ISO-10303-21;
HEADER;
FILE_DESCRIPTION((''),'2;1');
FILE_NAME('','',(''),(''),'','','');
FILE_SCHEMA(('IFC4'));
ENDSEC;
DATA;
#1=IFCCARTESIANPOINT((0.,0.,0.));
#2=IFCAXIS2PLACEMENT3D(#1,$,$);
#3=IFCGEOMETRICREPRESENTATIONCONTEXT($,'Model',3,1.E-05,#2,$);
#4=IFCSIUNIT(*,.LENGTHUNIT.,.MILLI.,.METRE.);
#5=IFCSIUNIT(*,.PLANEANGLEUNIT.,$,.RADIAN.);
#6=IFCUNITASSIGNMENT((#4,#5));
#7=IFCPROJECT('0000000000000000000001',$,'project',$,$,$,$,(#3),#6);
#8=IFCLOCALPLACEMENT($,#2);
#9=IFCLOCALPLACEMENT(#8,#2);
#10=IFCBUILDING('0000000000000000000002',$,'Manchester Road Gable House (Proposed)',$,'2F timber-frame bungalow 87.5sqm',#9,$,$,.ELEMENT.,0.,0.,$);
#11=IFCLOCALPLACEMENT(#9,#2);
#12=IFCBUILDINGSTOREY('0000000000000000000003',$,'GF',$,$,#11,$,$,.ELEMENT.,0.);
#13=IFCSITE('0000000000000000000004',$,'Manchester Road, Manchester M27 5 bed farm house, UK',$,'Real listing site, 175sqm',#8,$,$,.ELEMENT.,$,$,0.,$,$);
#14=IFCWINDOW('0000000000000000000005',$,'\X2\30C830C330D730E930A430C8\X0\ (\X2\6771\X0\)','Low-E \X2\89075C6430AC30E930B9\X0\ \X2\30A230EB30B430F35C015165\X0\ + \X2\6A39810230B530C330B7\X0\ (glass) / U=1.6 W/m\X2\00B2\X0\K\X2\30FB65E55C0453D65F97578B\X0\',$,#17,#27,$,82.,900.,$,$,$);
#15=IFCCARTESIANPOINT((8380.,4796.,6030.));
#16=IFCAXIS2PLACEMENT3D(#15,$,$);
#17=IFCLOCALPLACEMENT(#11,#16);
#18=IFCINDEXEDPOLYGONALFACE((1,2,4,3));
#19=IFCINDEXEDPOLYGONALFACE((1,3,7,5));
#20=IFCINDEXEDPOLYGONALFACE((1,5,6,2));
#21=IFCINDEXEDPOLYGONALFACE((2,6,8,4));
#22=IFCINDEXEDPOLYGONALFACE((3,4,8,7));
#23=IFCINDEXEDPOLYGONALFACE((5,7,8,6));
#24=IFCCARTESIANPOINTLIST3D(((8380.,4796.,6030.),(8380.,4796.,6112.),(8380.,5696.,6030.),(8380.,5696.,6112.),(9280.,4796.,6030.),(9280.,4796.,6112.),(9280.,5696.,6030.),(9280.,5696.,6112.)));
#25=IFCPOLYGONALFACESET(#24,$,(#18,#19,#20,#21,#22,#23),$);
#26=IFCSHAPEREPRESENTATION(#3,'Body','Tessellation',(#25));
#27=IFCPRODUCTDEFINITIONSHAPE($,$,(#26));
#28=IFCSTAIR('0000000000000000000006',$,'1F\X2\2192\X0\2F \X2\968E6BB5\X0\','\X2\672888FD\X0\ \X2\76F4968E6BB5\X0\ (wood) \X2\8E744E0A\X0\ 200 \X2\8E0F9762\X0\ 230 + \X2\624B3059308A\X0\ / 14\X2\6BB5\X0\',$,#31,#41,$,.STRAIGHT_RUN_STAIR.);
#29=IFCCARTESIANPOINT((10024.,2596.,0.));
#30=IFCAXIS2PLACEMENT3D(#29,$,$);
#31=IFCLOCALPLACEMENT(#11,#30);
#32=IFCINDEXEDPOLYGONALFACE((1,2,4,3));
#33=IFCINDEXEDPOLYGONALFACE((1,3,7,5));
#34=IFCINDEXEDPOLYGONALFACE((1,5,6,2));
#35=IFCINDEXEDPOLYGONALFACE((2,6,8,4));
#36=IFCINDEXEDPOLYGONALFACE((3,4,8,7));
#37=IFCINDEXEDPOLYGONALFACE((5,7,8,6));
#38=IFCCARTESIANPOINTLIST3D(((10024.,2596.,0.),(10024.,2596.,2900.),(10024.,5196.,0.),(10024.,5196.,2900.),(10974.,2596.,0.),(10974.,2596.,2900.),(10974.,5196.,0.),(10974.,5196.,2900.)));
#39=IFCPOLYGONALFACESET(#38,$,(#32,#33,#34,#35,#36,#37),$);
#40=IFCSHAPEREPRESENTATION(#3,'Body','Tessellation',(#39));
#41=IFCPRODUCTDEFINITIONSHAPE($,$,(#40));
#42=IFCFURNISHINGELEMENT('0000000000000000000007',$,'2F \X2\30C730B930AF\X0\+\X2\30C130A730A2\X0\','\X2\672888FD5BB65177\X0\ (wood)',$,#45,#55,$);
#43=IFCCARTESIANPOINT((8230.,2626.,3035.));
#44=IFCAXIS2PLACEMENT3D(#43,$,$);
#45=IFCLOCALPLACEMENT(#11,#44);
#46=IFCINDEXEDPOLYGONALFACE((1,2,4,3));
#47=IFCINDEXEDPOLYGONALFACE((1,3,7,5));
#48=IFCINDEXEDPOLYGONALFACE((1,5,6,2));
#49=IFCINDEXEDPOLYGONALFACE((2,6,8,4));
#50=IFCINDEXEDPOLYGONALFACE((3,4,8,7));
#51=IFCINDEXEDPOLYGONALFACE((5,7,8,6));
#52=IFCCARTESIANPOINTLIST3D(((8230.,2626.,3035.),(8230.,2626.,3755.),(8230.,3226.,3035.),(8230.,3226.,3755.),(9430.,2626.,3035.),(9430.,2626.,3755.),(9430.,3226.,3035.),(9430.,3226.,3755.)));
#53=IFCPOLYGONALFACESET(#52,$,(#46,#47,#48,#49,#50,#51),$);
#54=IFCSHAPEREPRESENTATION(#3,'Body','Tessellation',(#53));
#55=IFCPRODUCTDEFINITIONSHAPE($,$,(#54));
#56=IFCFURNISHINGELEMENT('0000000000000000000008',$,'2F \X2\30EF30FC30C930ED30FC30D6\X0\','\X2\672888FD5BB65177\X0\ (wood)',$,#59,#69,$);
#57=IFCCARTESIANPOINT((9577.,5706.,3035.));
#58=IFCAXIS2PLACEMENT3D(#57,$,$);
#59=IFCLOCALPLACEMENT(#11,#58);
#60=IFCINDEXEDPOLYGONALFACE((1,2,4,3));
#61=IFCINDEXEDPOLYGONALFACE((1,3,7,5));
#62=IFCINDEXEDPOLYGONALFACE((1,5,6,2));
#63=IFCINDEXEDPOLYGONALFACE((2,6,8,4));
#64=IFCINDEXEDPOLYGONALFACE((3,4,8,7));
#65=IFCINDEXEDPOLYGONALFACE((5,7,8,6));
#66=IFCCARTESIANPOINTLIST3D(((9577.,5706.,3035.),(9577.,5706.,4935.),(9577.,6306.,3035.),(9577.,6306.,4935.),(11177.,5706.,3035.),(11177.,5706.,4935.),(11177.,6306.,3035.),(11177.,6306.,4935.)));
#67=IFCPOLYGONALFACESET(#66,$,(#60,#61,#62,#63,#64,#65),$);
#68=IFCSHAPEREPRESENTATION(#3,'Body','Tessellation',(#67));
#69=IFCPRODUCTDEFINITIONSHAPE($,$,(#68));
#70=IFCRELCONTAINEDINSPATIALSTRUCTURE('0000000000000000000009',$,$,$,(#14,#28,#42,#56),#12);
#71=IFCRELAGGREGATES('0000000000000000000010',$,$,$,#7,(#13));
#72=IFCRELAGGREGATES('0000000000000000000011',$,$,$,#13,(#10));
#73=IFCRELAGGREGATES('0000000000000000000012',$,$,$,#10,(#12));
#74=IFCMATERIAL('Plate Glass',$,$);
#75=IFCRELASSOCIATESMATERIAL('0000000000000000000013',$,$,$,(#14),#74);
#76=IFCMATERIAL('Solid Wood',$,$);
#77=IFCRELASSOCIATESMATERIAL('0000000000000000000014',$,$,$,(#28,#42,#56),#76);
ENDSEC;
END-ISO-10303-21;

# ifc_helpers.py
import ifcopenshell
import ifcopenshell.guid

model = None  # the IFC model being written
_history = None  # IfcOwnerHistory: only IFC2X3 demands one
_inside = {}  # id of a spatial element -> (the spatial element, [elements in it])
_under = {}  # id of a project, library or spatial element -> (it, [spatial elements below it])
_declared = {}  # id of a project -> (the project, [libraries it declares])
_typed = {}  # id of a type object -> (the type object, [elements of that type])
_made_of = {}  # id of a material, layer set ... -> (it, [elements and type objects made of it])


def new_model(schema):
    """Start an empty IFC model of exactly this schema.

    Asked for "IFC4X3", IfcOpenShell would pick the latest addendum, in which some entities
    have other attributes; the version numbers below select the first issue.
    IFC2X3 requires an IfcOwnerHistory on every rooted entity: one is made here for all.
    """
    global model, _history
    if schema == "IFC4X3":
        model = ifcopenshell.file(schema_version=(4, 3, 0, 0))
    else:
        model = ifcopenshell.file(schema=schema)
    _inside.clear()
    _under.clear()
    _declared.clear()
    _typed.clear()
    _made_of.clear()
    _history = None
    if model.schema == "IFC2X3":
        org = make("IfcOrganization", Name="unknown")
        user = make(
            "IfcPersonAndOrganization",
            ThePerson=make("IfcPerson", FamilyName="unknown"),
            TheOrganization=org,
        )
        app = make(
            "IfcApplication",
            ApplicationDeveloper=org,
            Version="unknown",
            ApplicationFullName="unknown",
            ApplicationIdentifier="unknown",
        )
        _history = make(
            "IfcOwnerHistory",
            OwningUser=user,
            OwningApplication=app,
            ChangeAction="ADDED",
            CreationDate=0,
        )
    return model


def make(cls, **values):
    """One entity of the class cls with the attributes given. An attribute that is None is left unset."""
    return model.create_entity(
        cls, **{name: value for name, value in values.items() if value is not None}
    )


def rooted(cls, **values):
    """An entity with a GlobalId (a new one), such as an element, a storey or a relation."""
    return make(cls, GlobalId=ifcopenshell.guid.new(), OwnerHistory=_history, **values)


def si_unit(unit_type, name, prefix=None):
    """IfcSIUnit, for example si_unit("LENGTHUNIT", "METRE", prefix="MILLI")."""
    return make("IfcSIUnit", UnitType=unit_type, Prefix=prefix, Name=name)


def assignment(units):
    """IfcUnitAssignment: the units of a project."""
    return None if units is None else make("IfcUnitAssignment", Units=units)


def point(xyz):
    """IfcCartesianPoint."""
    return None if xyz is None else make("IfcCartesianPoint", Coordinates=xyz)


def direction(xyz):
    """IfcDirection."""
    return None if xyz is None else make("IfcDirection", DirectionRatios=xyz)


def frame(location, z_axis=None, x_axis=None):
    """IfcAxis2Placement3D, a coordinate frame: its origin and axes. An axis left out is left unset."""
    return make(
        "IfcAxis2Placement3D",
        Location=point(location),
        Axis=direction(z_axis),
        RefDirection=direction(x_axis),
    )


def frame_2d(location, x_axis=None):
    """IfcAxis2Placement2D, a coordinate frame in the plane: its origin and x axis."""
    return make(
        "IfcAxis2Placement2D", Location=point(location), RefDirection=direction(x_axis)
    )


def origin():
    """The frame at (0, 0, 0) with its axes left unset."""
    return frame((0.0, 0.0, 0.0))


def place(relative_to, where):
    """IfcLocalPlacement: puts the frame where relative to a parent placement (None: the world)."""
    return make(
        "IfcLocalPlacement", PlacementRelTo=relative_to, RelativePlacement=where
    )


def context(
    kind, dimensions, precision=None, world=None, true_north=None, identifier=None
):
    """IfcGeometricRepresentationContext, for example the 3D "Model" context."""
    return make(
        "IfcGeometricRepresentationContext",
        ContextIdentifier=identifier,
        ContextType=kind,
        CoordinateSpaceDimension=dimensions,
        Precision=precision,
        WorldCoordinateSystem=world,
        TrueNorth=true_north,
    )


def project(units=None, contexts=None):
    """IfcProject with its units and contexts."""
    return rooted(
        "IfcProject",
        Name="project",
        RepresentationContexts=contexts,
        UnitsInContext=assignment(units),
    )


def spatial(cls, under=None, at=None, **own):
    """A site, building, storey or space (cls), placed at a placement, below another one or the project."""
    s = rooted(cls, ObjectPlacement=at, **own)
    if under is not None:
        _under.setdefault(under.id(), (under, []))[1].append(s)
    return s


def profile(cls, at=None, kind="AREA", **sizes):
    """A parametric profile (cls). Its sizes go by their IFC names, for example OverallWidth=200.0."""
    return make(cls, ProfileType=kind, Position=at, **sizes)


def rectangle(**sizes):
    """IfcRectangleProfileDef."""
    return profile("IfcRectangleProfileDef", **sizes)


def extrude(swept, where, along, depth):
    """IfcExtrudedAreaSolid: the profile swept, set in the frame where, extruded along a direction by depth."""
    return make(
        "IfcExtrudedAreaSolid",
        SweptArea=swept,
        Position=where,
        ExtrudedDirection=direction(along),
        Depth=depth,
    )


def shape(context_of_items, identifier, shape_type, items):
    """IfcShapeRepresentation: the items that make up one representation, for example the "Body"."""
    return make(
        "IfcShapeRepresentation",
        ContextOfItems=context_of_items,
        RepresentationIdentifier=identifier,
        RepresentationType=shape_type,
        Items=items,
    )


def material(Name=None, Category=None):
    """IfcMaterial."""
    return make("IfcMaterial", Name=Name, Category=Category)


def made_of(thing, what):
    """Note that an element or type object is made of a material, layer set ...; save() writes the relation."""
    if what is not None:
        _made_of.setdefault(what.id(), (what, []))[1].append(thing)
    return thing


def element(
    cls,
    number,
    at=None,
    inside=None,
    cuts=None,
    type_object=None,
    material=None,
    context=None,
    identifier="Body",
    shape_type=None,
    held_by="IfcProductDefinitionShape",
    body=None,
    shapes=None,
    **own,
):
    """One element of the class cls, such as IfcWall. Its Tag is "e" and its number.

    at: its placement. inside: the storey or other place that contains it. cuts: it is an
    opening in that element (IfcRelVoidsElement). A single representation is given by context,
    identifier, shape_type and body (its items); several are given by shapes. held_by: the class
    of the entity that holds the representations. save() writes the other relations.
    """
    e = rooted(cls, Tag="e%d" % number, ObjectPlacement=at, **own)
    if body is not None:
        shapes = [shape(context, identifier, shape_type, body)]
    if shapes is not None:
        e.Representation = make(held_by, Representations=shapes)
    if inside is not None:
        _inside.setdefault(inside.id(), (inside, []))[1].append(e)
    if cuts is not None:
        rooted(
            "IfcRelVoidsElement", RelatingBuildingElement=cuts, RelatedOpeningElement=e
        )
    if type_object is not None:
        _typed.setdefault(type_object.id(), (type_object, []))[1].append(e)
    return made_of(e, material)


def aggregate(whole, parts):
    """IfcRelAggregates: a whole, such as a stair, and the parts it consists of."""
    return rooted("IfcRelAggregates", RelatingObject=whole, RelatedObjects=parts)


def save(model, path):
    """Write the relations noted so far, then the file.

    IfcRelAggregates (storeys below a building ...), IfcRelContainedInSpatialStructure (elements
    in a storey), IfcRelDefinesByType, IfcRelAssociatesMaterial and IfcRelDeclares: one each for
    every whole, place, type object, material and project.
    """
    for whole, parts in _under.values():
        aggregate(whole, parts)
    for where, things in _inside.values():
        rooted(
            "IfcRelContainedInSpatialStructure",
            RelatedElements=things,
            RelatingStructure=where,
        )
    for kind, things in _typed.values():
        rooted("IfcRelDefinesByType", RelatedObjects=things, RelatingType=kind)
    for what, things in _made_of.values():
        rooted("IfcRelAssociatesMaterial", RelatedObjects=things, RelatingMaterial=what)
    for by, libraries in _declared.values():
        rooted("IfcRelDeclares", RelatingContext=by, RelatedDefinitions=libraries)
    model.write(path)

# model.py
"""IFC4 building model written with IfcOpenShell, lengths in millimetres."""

from ifc_helpers import new_model, si_unit, frame, frame_2d, origin, place, context, project, spatial, rectangle, extrude, material, element, save


model = new_model("IFC4")

# Units and contexts
model_context = context("Model", 3, precision=1e-05, world=origin())
ifc_project = project(units=[si_unit("LENGTHUNIT", "METRE", prefix="MILLI"), si_unit("PLANEANGLEUNIT", "RADIAN")], contexts=[model_context])

# Site, building, storey
site_placement = place(None, origin())
site = spatial("IfcSite", under=ifc_project, at=site_placement, Name="Manchester Road, Manchester M27 5 bed farm house, UK", ObjectType="Real listing site, 175sqm", CompositionType="ELEMENT", RefElevation=0.0)
building_placement = place(site_placement, origin())
building = spatial("IfcBuilding", under=site, at=building_placement, Name="Manchester Road Gable House (Proposed)", ObjectType="2F timber-frame bungalow 87.5sqm", CompositionType="ELEMENT", ElevationOfRefHeight=0.0, ElevationOfTerrain=0.0)
storey_placement = place(building_placement, origin())
storey = spatial("IfcBuildingStorey", under=building, at=storey_placement, Name="GF", CompositionType="ELEMENT", Elevation=0.0)

# Shared definitions
ifc_material_1 = material(Name="Solid Wood")

# Shared definitions
ifc_material_2 = material(Name="Plate Glass")

# Window
window_1_placement = place(storey_placement, frame((8380.0, 4796.0, 6030.0)))
element("IfcWindow", 1, at=window_1_placement, inside=storey, material=ifc_material_2, Name="トップライト (東)", Description="Low-E 複層ガラス アルゴン封入 + 樹脂サッシ (glass) / U=1.6 W/m²K・日射取得型", OverallHeight=82.0, OverallWidth=900.0, context=model_context, shape_type="SweptSolid", body=[
    extrude(rectangle(XDim=900.0, YDim=900.0, at=frame_2d((450.0, 450.0))), frame((8380.0, 4796.0, 6030.0)), (0.0, 0.0, 1.0), 82.0),
])

# Stair
stair_placement = place(storey_placement, frame((10024.0, 2596.0, 0.0)))
element("IfcStair", 2, at=stair_placement, inside=storey, material=ifc_material_1, Name="1F→2F 階段", Description="木製 直階段 (wood) 蹴上 200 踏面 230 + 手すり / 14段", PredefinedType="STRAIGHT_RUN_STAIR", context=model_context, shape_type="SweptSolid", body=[
    extrude(rectangle(XDim=950.0, YDim=2600.0, at=frame_2d((475.0, 1300.0))), frame((10024.0, 2596.0, 0.0)), (0.0, 0.0, 1.0), 2900.0),
])

# Furnishing elements
furnishing_1_placement = place(storey_placement, frame((8230.0, 2626.0, 3035.0)))
element("IfcFurnishingElement", 3, at=furnishing_1_placement, inside=storey, material=ifc_material_1, Name="2F デスク+チェア", Description="木製家具 (wood)", context=model_context, shape_type="SweptSolid", body=[
    extrude(rectangle(XDim=1200.0, YDim=600.0, at=frame_2d((600.0, 300.0))), frame((8230.0, 2626.0, 3035.0)), (0.0, 0.0, 1.0), 720.0),
])
furnishing_2_placement = place(storey_placement, frame((9577.0, 5706.0, 3035.0)))
element("IfcFurnishingElement", 4, at=furnishing_2_placement, inside=storey, material=ifc_material_1, Name="2F ワードローブ", Description="木製家具 (wood)", context=model_context, shape_type="SweptSolid", body=[
    extrude(rectangle(XDim=1600.0, YDim=600.0, at=frame_2d((800.0, 300.0))), frame((9577.0, 5706.0, 3035.0)), (0.0, 0.0, 1.0), 1900.0),
])

save(model, "model.ifc")
